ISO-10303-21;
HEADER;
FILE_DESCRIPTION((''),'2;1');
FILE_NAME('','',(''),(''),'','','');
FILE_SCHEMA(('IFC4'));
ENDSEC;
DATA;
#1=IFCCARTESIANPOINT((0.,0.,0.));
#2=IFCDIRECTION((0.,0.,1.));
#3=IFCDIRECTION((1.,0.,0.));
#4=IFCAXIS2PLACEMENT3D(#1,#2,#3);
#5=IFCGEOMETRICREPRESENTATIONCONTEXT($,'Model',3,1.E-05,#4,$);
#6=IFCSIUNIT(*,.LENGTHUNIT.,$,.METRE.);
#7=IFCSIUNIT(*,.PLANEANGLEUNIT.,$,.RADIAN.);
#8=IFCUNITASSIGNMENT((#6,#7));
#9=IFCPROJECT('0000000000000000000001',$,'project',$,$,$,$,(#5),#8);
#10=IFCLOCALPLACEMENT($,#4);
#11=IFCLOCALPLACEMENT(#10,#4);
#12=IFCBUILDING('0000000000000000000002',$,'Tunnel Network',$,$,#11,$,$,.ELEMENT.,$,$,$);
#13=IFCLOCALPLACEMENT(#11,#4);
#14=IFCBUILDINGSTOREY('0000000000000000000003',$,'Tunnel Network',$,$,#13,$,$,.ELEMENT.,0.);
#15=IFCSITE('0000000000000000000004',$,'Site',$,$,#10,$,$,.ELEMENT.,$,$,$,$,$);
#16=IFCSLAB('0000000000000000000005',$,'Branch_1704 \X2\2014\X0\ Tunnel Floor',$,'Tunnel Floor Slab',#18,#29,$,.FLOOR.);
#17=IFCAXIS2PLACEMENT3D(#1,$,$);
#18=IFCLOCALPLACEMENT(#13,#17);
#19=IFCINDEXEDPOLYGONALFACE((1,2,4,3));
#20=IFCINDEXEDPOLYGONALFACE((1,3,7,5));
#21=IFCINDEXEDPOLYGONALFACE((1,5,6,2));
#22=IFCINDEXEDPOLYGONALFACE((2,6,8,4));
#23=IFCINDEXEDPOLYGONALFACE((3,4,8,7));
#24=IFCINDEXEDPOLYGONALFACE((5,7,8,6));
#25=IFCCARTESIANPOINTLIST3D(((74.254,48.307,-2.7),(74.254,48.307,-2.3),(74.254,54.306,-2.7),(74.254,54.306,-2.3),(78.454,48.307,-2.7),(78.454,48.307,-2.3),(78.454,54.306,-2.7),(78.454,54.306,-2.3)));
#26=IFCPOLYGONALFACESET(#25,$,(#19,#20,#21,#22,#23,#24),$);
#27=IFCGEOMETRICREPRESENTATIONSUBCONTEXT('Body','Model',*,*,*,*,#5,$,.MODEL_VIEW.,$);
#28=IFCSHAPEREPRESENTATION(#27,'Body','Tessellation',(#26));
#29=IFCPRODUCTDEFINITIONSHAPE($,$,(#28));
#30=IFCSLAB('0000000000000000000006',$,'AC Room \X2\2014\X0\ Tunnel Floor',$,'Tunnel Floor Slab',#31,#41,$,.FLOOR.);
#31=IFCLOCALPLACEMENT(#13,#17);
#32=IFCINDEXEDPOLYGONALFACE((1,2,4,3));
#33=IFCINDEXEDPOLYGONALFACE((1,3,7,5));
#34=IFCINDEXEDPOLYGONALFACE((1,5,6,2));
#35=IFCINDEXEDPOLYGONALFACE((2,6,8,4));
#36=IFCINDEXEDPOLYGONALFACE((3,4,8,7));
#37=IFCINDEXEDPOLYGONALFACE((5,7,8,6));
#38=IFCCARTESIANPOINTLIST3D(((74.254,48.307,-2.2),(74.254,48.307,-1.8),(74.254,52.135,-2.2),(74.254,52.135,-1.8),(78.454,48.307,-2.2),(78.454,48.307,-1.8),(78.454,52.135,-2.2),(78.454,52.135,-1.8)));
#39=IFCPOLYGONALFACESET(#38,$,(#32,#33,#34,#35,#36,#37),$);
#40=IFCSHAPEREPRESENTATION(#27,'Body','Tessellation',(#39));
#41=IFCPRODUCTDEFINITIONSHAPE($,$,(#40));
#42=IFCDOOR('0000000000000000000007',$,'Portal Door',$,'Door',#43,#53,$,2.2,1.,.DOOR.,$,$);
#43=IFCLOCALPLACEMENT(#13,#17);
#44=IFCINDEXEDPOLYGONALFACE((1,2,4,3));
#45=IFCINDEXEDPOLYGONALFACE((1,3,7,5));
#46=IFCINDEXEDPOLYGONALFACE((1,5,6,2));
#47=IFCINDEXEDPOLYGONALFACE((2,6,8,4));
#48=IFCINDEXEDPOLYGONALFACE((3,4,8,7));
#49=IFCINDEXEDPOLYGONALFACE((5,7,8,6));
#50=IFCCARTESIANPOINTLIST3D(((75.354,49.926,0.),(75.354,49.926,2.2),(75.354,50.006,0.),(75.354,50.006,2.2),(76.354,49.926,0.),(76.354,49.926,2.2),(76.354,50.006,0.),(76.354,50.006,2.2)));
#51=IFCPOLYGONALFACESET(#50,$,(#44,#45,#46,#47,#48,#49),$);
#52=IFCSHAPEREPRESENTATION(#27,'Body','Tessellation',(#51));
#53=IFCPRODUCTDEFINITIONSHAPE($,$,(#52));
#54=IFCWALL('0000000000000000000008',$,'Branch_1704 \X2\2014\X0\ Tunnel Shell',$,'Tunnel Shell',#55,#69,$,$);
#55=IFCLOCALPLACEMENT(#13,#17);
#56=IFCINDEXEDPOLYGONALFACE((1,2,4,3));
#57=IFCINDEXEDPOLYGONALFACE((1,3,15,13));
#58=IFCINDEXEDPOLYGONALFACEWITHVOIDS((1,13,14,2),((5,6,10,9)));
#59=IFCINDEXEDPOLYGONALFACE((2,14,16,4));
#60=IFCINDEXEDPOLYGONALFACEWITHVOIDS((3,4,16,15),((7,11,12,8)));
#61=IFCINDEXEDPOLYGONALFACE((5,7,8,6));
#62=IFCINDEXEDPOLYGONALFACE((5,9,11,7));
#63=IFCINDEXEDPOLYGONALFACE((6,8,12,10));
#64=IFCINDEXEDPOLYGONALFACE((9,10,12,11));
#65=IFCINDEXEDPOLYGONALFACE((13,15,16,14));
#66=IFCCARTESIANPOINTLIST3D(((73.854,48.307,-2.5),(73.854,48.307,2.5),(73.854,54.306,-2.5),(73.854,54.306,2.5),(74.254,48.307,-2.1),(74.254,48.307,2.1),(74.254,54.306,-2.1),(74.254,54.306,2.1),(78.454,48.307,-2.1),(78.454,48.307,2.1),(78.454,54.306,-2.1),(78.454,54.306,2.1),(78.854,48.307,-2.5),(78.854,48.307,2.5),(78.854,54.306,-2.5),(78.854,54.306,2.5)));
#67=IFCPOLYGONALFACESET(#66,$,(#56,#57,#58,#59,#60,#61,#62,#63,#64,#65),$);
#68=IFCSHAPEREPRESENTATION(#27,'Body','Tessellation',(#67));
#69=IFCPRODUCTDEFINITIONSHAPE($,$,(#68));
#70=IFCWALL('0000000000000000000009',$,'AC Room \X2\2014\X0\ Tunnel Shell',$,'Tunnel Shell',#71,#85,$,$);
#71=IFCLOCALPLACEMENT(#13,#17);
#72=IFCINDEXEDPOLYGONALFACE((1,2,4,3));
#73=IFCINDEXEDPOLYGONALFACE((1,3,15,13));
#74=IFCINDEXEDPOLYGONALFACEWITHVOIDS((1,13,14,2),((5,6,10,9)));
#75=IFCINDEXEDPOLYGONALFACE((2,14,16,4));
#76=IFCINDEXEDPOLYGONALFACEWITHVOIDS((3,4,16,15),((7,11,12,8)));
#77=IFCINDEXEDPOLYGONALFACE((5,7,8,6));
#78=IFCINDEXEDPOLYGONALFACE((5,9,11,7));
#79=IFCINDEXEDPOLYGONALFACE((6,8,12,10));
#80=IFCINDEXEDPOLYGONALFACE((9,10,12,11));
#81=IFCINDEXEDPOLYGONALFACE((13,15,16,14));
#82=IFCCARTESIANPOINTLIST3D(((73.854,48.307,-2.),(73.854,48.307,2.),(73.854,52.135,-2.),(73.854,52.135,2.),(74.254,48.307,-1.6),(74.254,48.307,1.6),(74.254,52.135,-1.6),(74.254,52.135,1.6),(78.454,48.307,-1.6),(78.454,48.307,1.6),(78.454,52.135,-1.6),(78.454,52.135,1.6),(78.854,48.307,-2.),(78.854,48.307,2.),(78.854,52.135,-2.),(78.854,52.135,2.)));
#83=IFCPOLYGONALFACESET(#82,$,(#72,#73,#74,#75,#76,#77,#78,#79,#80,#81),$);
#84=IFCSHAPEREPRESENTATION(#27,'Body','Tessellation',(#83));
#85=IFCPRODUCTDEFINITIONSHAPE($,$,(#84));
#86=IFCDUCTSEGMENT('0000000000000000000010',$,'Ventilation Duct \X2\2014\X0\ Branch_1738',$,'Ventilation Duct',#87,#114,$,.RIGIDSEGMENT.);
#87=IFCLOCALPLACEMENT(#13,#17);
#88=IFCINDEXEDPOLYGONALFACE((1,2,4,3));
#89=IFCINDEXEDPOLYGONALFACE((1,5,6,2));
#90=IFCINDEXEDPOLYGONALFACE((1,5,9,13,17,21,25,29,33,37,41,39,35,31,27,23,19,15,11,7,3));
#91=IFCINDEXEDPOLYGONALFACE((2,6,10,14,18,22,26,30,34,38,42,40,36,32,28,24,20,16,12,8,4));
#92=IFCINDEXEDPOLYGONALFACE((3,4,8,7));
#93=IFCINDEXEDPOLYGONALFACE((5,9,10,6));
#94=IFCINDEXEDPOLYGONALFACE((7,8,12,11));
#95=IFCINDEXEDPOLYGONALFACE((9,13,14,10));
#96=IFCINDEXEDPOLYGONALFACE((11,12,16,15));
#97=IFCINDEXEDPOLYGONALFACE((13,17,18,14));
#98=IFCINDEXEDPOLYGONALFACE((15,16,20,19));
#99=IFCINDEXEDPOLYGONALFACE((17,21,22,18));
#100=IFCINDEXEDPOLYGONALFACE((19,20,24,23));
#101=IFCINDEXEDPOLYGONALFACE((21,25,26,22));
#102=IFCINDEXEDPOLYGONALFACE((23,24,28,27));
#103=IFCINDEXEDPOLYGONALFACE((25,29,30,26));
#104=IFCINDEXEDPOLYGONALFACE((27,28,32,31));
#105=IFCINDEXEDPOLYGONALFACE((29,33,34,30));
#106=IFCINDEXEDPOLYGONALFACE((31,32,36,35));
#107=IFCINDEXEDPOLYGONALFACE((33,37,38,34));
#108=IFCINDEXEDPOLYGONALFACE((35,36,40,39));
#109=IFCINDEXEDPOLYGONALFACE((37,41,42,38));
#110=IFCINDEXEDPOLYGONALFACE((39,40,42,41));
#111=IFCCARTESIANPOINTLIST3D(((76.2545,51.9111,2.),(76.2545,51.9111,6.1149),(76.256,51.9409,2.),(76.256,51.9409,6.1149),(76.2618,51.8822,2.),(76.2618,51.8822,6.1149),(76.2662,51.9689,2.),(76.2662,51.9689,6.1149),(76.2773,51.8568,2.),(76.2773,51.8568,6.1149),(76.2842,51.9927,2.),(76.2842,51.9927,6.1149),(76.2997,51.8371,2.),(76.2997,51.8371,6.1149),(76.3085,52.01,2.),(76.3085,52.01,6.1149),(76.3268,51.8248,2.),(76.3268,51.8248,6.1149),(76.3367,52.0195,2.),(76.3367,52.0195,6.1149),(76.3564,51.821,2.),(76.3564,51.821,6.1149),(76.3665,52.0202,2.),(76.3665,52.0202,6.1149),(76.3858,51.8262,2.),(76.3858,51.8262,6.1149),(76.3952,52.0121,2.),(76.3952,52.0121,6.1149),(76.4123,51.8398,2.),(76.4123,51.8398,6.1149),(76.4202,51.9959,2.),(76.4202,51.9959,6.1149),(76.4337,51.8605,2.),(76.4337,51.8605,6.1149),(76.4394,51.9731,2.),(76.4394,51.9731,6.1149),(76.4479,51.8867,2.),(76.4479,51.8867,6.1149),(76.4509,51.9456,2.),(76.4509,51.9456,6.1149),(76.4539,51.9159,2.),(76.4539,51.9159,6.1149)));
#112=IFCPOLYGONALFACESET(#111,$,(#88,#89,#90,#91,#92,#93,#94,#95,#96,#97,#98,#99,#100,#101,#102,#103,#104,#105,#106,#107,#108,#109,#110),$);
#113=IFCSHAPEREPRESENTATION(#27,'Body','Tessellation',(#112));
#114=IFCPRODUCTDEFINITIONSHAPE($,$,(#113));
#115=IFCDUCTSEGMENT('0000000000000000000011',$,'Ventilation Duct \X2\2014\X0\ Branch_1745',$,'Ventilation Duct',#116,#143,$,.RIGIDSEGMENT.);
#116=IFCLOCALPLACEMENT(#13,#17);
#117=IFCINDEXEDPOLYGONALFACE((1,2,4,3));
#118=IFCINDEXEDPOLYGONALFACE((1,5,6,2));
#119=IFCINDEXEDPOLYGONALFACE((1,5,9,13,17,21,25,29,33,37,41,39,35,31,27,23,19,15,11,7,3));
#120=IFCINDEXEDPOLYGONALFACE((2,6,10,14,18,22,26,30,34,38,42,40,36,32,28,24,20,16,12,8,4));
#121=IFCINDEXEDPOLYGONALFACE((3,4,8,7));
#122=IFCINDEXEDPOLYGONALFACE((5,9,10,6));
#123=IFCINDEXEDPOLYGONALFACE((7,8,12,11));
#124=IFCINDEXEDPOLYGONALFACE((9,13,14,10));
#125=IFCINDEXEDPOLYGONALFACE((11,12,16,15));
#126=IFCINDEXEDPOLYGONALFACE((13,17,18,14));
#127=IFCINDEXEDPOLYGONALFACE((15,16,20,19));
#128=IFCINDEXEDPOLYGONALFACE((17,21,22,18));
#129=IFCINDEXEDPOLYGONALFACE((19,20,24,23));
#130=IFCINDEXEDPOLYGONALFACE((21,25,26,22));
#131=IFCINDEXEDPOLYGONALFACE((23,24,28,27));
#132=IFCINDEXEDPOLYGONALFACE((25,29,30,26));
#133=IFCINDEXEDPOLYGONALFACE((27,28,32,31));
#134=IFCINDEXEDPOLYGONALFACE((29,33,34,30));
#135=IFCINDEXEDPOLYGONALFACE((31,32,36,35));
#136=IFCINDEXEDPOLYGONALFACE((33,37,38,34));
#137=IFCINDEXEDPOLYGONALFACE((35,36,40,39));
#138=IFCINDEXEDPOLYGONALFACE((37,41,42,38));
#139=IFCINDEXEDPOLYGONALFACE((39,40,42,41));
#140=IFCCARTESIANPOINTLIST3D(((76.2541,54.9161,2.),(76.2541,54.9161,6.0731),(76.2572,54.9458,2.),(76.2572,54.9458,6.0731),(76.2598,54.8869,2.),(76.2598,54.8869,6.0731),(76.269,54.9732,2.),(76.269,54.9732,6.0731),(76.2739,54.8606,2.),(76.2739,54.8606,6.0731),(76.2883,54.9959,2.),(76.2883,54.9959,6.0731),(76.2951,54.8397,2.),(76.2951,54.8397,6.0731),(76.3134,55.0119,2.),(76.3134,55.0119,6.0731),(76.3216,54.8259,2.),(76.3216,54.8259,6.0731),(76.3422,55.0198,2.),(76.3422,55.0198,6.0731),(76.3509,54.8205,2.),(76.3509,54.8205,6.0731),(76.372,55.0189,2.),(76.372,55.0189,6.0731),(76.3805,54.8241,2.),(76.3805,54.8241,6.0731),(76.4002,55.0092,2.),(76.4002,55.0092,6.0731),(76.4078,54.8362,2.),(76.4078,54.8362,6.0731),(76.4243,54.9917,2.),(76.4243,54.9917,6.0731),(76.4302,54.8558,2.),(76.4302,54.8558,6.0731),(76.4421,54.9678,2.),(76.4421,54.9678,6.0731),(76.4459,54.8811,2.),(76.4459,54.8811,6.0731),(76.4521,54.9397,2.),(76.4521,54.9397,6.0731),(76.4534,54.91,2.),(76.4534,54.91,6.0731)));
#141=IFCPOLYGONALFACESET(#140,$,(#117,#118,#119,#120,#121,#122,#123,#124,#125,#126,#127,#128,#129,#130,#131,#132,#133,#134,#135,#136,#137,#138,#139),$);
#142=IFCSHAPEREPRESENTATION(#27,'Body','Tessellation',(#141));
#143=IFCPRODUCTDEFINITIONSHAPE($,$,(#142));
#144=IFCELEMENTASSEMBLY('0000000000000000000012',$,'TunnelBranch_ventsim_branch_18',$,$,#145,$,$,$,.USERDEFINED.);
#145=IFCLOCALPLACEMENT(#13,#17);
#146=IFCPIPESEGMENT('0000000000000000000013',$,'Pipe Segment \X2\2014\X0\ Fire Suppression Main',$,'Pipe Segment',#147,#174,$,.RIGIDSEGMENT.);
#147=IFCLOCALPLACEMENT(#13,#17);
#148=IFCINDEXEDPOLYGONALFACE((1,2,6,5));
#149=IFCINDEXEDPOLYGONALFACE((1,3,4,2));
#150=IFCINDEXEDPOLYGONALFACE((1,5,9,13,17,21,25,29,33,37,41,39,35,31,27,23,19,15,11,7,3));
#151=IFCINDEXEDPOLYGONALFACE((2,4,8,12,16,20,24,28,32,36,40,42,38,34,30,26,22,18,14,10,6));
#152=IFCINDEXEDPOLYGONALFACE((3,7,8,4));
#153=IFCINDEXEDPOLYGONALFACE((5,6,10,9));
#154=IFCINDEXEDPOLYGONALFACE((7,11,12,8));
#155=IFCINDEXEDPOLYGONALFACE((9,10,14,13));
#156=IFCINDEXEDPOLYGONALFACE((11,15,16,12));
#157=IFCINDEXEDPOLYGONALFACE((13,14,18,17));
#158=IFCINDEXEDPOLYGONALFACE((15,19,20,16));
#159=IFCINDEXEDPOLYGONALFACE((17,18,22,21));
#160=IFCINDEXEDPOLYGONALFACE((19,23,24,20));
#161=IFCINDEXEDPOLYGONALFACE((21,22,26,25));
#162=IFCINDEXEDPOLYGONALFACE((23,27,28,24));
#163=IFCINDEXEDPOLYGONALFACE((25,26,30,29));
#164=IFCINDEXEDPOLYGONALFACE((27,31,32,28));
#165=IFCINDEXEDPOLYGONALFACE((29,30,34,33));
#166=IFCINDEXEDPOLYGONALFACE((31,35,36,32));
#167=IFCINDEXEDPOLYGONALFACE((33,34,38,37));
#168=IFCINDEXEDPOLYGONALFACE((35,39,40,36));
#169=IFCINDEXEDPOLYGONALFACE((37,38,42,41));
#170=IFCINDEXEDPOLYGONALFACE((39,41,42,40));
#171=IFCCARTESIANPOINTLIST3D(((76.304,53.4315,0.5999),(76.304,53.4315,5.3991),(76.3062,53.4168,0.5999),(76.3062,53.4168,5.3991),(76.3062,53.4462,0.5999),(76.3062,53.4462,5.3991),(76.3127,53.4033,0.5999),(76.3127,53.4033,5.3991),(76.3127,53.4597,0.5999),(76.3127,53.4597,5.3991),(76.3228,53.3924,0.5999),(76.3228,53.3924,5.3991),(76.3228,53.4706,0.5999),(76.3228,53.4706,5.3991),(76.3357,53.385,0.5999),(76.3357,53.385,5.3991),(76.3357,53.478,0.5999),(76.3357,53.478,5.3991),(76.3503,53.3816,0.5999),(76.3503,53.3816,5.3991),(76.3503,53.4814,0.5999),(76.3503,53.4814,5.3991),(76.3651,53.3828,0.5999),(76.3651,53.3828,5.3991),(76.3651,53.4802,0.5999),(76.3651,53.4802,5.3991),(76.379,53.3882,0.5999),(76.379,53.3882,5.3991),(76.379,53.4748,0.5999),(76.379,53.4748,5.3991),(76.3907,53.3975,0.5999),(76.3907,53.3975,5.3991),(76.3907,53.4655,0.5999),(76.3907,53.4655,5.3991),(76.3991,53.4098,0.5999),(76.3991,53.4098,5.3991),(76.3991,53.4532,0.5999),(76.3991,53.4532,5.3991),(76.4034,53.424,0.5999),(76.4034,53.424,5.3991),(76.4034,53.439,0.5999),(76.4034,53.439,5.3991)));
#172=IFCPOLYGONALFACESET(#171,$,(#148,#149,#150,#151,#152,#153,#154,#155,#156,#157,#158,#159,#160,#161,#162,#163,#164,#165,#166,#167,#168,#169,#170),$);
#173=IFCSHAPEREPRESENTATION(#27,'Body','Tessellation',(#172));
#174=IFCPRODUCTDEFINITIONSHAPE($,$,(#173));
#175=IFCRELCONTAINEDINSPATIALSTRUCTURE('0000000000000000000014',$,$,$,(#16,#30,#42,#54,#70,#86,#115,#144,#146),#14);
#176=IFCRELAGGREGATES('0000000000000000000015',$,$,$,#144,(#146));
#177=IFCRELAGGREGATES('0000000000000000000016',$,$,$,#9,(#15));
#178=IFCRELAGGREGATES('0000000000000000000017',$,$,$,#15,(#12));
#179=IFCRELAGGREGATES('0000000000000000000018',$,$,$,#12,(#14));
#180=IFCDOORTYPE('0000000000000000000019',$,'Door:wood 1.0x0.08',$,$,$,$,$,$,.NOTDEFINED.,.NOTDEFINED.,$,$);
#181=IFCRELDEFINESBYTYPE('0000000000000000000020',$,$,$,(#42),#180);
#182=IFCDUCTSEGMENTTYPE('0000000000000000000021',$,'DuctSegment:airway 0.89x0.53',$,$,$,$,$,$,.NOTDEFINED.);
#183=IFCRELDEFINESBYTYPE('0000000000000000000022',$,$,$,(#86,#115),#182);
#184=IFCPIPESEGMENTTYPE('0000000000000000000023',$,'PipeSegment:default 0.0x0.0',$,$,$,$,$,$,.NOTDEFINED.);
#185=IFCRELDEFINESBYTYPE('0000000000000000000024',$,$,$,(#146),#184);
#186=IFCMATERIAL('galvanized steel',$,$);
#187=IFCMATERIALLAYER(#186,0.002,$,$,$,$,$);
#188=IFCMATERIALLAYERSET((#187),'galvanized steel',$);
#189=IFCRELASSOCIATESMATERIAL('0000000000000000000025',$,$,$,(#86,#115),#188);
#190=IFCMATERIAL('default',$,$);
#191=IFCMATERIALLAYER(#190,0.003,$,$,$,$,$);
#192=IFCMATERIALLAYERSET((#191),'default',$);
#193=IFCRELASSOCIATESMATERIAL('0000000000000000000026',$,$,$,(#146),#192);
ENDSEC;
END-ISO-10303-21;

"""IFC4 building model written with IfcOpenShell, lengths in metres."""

from ifc_helpers import new_model, entity, si_unit, frame, origin_with_axes, origin_2d_with_axis, place, context, subcontext, project, spatial, rectangle, hollow_rectangle, circle, extrude, material, layer, layer_set, layer_usage, type_object, element, aggregate, save


model = new_model("IFC4")

# Units and contexts
model_context = context("Model", 3, precision=1e-05, world=origin_with_axes())
body_context = subcontext(model_context, "Body", "Model", "MODEL_VIEW")
ifc_project = project(units=[si_unit("LENGTHUNIT", "METRE"), si_unit("PLANEANGLEUNIT", "RADIAN")], contexts=[model_context])

# Site, building, storey
site_placement = place(None, origin_with_axes())
site = spatial("IfcSite", under=ifc_project, at=site_placement, Name="Site", CompositionType="ELEMENT")
building_placement = place(site_placement, origin_with_axes())
building = spatial("IfcBuilding", under=site, at=building_placement, Name="Tunnel Network", CompositionType="ELEMENT")
storey_placement = place(building_placement, origin_with_axes())
storey = spatial("IfcBuildingStorey", under=building, at=storey_placement, Name="Tunnel Network", CompositionType="ELEMENT", Elevation=0.0)

# Slabs
placement_1 = place(storey_placement, frame((76.354, 54.306, 0.0), z_axis=(0.0, 0.0, 1.0), x_axis=(0.0, -1.0, 0.0)))
element("IfcSlab", 1, at=placement_1, inside=storey, Name="Branch_1704 — Tunnel Floor", ObjectType="Tunnel Floor Slab", PredefinedType="FLOOR", context=body_context, shape_type="SweptSolid", body=[
    extrude(rectangle(XDim=0.4, YDim=4.2, at=origin_2d_with_axis()), frame((0.0, 0.0, -2.5), z_axis=(1.0, 0.0, 0.0), x_axis=(0.0, 0.0, 1.0)), (0.0, 0.0, 1.0), 5.999),
])
placement_2 = place(storey_placement, frame((76.354, 48.307, 0.0), z_axis=(0.0, 0.0, 1.0), x_axis=(0.0, 1.0, 0.0)))
element("IfcSlab", 2, at=placement_2, inside=storey, Name="AC Room — Tunnel Floor", ObjectType="Tunnel Floor Slab", PredefinedType="FLOOR", context=body_context, shape_type="SweptSolid", body=[
    extrude(rectangle(XDim=0.4, YDim=4.2, at=origin_2d_with_axis()), frame((0.0, 0.0, -2.0), z_axis=(1.0, 0.0, 0.0), x_axis=(0.0, 0.0, 1.0)), (0.0, 0.0, 1.0), 3.828),
])

# Door
door_type = type_object("IfcDoorType", Name="Door:wood 1.0x0.08")
door_placement = place(storey_placement, frame((75.854, 49.966, 0.0), z_axis=(0.0, 0.0, 1.0), x_axis=(1.0, 0.0, 0.0)))
element("IfcDoor", 3, at=door_placement, inside=storey, type_object=door_type, Name="Portal Door", ObjectType="Door", OverallHeight=2.2, OverallWidth=1.0, PredefinedType="DOOR", context=body_context, shape_type="SweptSolid", body=[
    extrude(rectangle(XDim=1.0, YDim=0.08, at=origin_2d_with_axis()), origin_with_axes(), (0.0, 0.0, 1.0), 2.2),
])

# Walls
element("IfcWall", 4, at=placement_1, inside=storey, Name="Branch_1704 — Tunnel Shell", ObjectType="Tunnel Shell", context=body_context, shape_type="SweptSolid", body=[
    extrude(hollow_rectangle(XDim=5.0, YDim=5.0, WallThickness=0.4, at=origin_2d_with_axis()), frame((0.0, 0.0, 0.0), z_axis=(1.0, 0.0, 0.0), x_axis=(0.0, 0.0, 1.0)), (0.0, 0.0, 1.0), 5.999),
])
element("IfcWall", 5, at=placement_2, inside=storey, Name="AC Room — Tunnel Shell", ObjectType="Tunnel Shell", context=body_context, shape_type="SweptSolid", body=[
    extrude(hollow_rectangle(XDim=4.0, YDim=5.0, WallThickness=0.4, at=origin_2d_with_axis()), frame((0.0, 0.0, 0.0), z_axis=(1.0, 0.0, 0.0), x_axis=(0.0, 0.0, 1.0)), (0.0, 0.0, 1.0), 3.828),
])

# Duct segments
ifc_material_1 = material(Name="galvanized steel")
ifc_layer_1 = layer(ifc_material_1, 0.002)
ifc_layer_set_1 = layer_set([ifc_layer_1], Name="galvanized steel")
ifc_layer_usage_1 = layer_usage(ifc_layer_set_1, "AXIS2", "POSITIVE", 0.0)
duct_segment_type = type_object("IfcDuctSegmentType", Name="DuctSegment:airway 0.89x0.53")
duct_segment_1_placement = place(storey_placement, frame((76.354, 51.921, 2.0), z_axis=(0.0, 0.0, 1.0), x_axis=(0.125309, 0.992118, 0.0)))
element("IfcDuctSegment", 6, at=duct_segment_1_placement, inside=storey, type_object=duct_segment_type, material=ifc_layer_usage_1, Name="Ventilation Duct — Branch_1738", ObjectType="Ventilation Duct", PredefinedType="RIGIDSEGMENT", context=body_context, shape_type="AdvancedSweptSolid", body=[
    entity("IfcSweptDiskSolid", entity("IfcPolyline", [entity("IfcCartesianPoint", [0.0, 0.0, 0.0]), entity("IfcCartesianPoint", [0.0, 0.0, 4.1149])]), 0.1),
])
ifc_layer_usage_2 = layer_usage(ifc_layer_set_1, "AXIS2", "POSITIVE", 0.0)
duct_segment_2_placement = place(storey_placement, frame((76.354, 54.9205, 2.0), z_axis=(0.0, 0.0, 1.0), x_axis=(-0.118427, 0.992963, 0.0)))
element("IfcDuctSegment", 7, at=duct_segment_2_placement, inside=storey, type_object=duct_segment_type, material=ifc_layer_usage_2, Name="Ventilation Duct — Branch_1745", ObjectType="Ventilation Duct", PredefinedType="RIGIDSEGMENT", context=body_context, shape_type="AdvancedSweptSolid", body=[
    entity("IfcSweptDiskSolid", entity("IfcPolyline", [entity("IfcCartesianPoint", [0.0, 0.0, 0.0]), entity("IfcCartesianPoint", [0.0, 0.0, 4.0731])]), 0.1),
])

# Element assembly, pipe segment
assembly_1_placement = place(storey_placement, frame((76.354, 53.4315, 1.0), z_axis=(0.0, 1.0, 0.0), x_axis=(-1.0, 0.0, 0.0)))
assembly_1 = element("IfcElementAssembly", 8, at=assembly_1_placement, inside=storey, Name="TunnelBranch_ventsim_branch_18", PredefinedType="USERDEFINED")
ifc_material_2 = material(Name="default")
ifc_layer_2 = layer(ifc_material_2, 0.003)
ifc_layer_set_2 = layer_set([ifc_layer_2], Name="default")
ifc_layer_usage_3 = layer_usage(ifc_layer_set_2, "AXIS2", "POSITIVE", 0.0)
pipe_segment_type = type_object("IfcPipeSegmentType", Name="PipeSegment:default 0.0x0.0")
pipe_segment_1_placement = place(storey_placement, frame((76.354, 53.4315, 0.5999), z_axis=(0.0, 0.0, 1.0), x_axis=(-1.0, 0.0, 0.0)))
pipe_segment_1 = element("IfcPipeSegment", 9, at=pipe_segment_1_placement, inside=storey, type_object=pipe_segment_type, material=ifc_layer_usage_3, Name="Pipe Segment — Fire Suppression Main", ObjectType="Pipe Segment", PredefinedType="RIGIDSEGMENT", context=body_context, shape_type="SweptSolid", body=[
    extrude(circle(Radius=0.05, at=origin_2d_with_axis()), origin_with_axes(), (0.0, 0.0, 1.0), 4.7992),
])

aggregate(assembly_1, [pipe_segment_1])

save(model, "model.ifc")
